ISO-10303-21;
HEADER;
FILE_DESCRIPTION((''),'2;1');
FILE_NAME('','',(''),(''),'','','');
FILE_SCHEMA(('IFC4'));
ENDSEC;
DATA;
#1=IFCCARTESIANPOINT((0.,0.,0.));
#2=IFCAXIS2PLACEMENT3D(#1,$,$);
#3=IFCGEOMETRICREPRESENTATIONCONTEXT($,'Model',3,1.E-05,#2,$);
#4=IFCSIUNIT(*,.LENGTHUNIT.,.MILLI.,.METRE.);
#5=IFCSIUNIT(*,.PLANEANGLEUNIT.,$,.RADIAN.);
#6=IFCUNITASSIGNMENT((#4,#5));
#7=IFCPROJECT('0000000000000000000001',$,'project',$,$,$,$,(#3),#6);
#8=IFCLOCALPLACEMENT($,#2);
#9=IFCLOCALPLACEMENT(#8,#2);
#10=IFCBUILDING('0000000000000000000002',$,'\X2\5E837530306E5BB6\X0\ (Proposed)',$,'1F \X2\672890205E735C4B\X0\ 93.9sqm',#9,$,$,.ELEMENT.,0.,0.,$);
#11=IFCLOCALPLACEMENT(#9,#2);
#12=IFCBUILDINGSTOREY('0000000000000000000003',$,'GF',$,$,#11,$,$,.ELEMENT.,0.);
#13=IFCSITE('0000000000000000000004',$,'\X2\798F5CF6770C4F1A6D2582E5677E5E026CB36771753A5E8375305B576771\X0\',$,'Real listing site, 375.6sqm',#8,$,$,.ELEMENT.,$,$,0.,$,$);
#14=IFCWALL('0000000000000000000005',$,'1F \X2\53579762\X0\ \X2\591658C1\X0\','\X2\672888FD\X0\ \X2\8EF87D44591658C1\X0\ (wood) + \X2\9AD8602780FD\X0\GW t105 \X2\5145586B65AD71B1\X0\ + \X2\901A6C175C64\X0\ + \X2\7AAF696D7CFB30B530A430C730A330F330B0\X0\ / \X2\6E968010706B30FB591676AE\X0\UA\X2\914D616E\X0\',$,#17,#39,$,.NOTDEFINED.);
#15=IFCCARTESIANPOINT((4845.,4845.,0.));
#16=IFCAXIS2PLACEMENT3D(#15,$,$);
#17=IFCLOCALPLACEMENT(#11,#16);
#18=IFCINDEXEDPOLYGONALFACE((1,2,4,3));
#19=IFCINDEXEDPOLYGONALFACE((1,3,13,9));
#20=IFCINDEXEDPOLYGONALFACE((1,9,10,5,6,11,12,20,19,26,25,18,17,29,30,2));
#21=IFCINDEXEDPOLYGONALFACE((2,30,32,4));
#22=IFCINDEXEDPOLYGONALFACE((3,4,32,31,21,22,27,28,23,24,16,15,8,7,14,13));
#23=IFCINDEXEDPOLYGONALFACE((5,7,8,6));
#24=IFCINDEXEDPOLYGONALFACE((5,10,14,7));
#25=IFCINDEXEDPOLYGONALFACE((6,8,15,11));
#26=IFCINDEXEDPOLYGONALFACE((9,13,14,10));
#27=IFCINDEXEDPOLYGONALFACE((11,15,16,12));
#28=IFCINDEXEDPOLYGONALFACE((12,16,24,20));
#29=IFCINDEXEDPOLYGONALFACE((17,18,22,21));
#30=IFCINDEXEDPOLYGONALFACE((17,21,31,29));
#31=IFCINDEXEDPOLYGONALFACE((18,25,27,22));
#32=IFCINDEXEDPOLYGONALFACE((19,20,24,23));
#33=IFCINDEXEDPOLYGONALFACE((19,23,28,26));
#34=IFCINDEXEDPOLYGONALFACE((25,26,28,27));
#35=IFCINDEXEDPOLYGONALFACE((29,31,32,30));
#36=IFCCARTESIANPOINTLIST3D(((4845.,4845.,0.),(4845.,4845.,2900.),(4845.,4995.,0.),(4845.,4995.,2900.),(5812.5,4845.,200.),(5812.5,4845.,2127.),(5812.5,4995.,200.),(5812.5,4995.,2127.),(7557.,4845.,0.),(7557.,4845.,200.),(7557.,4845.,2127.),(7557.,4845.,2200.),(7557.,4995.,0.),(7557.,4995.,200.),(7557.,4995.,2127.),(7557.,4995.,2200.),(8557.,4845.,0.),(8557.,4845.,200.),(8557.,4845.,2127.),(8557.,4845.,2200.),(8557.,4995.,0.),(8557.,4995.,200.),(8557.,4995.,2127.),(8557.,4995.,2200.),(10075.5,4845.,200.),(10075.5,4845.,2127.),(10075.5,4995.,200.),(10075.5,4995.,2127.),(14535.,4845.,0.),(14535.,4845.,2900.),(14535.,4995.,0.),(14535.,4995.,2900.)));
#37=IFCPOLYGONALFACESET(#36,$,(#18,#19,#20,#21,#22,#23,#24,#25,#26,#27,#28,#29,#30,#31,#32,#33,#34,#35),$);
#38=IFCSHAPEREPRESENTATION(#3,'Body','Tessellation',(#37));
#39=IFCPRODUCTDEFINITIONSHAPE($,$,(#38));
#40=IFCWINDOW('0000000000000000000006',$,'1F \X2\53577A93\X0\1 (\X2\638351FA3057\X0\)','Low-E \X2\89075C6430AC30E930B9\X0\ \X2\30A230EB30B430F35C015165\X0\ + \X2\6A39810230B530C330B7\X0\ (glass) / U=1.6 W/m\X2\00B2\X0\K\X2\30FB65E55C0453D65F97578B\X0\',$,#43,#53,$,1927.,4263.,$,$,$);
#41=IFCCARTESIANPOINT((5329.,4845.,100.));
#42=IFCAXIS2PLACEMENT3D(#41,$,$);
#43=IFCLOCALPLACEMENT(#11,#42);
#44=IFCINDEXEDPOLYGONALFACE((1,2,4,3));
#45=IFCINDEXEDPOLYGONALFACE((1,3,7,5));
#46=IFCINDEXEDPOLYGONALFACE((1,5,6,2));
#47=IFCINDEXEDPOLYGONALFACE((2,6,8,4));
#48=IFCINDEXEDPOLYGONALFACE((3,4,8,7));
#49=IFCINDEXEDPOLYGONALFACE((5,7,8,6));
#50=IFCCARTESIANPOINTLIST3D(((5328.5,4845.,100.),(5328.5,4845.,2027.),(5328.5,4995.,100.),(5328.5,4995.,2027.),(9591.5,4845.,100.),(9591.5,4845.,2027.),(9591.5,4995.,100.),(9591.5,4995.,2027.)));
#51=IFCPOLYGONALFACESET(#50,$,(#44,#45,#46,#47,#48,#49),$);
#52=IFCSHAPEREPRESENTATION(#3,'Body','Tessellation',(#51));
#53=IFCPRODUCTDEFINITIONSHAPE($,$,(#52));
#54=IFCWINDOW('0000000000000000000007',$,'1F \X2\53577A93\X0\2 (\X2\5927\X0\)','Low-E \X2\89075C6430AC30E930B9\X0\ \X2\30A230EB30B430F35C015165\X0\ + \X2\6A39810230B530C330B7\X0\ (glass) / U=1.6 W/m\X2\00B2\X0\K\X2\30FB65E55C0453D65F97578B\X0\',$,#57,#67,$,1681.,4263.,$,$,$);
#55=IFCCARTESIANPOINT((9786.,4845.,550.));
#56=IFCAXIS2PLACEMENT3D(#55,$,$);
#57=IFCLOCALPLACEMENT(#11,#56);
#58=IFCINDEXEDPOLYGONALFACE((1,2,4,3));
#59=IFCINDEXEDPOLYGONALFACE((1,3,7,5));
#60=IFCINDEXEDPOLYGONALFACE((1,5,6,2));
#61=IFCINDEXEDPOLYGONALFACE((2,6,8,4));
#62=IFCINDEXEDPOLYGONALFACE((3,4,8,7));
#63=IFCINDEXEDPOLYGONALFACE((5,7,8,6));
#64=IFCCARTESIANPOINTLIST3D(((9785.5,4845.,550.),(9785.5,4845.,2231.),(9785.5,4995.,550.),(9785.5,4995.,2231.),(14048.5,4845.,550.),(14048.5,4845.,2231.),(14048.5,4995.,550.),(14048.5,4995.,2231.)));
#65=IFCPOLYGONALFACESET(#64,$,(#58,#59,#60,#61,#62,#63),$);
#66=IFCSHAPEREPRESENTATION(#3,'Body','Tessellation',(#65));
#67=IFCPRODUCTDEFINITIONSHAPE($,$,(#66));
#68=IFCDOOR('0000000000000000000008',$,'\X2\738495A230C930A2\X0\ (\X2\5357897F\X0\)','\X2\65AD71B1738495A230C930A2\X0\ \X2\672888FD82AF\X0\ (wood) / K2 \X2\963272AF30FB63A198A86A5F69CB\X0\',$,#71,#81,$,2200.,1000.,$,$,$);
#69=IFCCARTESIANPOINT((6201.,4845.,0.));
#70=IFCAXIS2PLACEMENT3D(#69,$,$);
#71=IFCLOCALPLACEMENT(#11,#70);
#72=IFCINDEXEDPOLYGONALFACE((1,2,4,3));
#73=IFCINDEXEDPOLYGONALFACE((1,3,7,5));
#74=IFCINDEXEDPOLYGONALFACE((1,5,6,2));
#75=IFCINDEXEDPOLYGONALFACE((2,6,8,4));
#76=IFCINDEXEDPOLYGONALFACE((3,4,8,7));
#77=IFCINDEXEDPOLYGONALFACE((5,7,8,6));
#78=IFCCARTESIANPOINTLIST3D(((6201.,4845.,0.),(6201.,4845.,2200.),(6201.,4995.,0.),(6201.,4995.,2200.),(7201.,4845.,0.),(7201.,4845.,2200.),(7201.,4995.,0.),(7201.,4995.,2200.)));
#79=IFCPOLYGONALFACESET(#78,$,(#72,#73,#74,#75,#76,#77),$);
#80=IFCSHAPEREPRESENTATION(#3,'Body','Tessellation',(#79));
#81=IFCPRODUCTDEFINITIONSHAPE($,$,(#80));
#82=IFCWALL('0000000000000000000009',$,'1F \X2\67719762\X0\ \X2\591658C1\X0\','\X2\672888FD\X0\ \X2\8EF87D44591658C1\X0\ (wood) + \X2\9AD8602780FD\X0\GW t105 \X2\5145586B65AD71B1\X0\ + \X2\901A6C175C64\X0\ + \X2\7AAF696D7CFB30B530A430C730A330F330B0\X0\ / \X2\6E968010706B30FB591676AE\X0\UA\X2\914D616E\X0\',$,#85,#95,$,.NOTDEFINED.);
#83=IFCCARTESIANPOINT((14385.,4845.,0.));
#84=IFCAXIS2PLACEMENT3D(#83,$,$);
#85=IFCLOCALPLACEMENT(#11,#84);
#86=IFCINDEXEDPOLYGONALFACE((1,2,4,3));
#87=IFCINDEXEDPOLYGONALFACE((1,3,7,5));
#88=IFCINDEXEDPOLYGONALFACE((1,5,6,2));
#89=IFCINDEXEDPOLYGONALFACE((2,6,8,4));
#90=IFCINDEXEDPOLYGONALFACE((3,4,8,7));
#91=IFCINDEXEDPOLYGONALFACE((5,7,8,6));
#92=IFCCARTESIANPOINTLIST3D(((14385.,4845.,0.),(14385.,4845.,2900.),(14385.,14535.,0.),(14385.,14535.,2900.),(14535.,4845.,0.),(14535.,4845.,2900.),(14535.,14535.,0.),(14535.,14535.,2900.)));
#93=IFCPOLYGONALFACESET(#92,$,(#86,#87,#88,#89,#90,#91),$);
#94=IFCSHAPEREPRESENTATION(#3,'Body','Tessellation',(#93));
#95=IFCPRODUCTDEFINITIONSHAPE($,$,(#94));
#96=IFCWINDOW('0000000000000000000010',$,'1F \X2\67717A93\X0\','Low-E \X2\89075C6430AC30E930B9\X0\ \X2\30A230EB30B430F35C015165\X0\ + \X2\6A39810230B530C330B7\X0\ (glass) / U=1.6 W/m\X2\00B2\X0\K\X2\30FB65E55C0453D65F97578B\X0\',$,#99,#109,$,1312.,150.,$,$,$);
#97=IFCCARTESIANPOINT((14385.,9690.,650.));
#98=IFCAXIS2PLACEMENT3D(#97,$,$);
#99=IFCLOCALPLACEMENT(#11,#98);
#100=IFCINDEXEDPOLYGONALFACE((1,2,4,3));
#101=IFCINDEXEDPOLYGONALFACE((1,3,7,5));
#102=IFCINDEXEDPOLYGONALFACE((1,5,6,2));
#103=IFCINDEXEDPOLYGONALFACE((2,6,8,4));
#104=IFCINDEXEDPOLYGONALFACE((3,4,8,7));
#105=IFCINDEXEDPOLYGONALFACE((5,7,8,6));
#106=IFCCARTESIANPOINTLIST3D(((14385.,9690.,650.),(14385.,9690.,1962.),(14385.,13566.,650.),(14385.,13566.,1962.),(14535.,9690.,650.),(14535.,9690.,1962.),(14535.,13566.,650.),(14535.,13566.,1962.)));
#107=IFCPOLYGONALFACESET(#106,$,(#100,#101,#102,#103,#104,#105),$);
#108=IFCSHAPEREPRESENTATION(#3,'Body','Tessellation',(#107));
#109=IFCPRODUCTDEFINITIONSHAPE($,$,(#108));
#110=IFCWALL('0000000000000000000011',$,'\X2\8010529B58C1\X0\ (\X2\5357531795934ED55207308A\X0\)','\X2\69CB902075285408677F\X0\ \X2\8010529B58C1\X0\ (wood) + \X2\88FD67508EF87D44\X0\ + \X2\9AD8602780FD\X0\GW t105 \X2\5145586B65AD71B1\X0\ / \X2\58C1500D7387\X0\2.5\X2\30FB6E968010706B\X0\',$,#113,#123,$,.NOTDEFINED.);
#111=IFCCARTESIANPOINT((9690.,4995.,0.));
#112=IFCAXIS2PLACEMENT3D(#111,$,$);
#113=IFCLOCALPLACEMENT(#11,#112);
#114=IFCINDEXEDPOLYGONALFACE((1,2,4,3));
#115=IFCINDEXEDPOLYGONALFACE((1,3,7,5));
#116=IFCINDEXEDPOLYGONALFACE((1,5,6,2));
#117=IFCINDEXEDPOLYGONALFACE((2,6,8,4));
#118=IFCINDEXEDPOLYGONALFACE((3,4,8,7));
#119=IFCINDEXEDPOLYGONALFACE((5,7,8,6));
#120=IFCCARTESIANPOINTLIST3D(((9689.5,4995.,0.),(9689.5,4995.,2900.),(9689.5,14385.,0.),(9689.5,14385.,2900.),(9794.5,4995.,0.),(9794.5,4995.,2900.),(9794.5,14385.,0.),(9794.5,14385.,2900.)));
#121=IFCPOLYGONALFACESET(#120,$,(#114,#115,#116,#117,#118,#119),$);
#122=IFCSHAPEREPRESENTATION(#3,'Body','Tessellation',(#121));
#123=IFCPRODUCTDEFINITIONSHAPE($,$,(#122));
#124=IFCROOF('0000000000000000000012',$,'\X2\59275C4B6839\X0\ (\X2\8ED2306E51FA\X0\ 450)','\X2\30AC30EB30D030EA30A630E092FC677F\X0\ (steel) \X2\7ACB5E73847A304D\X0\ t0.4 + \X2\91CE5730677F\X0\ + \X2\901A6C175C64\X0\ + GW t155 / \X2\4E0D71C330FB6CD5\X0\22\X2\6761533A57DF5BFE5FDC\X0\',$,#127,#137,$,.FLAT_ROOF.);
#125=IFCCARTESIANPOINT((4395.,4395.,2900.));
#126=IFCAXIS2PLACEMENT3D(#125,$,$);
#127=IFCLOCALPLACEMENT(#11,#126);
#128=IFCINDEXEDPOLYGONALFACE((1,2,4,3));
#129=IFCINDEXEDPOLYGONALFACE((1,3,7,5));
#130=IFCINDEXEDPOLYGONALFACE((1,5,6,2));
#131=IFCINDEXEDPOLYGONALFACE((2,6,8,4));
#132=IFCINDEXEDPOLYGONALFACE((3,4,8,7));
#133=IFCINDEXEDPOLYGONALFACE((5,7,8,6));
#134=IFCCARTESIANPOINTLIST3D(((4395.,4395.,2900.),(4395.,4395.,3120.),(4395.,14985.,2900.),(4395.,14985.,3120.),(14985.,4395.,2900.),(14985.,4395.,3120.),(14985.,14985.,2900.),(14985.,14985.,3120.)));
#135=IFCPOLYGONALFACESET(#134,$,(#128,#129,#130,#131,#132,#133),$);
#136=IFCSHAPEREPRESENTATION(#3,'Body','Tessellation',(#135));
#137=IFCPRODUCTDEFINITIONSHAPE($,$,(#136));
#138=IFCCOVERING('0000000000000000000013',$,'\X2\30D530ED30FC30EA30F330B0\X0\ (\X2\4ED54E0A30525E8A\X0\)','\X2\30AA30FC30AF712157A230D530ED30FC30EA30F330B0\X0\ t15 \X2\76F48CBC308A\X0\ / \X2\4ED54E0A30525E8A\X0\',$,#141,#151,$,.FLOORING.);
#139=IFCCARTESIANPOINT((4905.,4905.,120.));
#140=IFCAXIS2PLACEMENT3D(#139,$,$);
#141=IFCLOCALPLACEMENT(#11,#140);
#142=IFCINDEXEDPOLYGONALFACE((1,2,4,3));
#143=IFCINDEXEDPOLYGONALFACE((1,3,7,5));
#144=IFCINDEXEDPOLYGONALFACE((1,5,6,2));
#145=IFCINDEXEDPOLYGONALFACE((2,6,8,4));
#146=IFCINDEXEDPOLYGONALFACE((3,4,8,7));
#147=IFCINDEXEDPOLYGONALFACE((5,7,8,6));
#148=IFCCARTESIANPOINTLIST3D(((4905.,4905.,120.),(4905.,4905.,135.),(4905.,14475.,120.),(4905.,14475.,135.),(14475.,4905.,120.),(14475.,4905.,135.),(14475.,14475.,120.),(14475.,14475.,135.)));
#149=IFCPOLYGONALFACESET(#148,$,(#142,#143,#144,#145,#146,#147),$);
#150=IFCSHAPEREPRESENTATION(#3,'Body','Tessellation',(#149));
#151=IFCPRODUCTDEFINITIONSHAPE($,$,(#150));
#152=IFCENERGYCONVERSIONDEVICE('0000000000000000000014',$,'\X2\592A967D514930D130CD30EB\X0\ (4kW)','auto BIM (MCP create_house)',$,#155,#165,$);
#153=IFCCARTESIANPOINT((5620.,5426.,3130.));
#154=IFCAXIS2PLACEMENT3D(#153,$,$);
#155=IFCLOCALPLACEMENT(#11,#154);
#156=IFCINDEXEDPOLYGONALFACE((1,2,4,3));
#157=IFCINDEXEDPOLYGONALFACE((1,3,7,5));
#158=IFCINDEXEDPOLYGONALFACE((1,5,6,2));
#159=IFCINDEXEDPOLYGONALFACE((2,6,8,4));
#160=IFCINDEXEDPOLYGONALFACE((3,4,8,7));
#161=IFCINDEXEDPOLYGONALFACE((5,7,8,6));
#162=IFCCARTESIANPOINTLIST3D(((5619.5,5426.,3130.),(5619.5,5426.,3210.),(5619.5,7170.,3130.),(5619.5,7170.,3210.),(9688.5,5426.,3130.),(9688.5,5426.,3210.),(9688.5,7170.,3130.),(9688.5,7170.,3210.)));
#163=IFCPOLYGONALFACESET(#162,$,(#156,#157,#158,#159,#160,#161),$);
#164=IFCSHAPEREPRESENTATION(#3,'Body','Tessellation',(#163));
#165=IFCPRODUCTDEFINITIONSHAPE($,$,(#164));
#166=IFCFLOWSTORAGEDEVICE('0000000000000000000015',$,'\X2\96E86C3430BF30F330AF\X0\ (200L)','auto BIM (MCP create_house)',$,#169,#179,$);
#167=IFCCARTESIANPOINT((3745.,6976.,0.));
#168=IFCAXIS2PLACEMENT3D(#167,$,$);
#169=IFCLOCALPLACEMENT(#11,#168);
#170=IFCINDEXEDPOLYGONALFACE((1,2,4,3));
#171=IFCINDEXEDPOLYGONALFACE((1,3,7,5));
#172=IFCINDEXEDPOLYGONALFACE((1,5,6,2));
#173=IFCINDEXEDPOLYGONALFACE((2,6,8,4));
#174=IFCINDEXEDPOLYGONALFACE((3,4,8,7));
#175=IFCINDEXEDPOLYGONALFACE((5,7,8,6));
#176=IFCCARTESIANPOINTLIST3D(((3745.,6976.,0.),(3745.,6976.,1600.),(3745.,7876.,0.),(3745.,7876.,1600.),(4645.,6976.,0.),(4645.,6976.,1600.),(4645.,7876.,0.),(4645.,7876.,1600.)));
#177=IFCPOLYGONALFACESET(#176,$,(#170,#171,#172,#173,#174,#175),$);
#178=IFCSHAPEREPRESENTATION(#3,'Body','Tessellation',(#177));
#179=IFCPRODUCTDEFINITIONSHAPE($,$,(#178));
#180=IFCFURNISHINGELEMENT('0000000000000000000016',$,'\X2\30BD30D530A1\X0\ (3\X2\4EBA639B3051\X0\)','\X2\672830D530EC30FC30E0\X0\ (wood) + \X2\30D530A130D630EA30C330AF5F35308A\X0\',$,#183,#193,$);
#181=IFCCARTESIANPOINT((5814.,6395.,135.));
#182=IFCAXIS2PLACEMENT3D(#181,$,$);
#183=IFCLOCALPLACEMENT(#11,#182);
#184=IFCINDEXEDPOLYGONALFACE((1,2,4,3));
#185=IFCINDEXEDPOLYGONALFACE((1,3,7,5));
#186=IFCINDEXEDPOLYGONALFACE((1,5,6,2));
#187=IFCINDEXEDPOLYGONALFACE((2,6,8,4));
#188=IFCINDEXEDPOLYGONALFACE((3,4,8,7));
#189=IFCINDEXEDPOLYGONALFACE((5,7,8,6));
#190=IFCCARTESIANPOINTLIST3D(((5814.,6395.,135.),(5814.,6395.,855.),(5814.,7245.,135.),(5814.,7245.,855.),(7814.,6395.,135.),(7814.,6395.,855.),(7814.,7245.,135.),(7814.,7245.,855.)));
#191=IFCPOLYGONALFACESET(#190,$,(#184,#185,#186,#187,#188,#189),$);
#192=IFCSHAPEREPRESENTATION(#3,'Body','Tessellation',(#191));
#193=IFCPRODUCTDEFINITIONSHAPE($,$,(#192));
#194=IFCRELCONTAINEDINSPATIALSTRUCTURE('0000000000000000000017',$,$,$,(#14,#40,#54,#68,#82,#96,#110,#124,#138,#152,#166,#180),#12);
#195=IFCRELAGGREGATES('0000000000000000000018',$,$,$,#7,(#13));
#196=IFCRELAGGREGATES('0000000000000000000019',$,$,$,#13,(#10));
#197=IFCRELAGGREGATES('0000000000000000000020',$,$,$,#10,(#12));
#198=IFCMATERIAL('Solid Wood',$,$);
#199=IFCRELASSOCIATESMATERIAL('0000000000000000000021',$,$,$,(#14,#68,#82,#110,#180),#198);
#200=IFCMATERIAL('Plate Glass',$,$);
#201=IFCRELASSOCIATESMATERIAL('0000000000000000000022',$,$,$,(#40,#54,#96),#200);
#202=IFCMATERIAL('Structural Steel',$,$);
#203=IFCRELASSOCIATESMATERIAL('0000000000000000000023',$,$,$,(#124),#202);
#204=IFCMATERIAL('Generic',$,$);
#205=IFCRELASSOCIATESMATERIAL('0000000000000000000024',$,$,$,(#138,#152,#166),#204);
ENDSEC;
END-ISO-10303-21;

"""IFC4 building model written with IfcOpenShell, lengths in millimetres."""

from ifc_helpers import new_model, si_unit, frame, frame_2d, origin, place, context, project, spatial, rectangle, extrude, material, element, fill, save


model = new_model("IFC4")

# Units and contexts
model_context = context("Model", 3, precision=1e-05, world=origin())
ifc_project = project(units=[si_unit("LENGTHUNIT", "METRE", prefix="MILLI"), si_unit("PLANEANGLEUNIT", "RADIAN")], contexts=[model_context])

# Site, building, storey
site_placement = place(None, origin())
site = spatial("IfcSite", under=ifc_project, at=site_placement, Name="福島県会津若松市河東町広田字東", ObjectType="Real listing site, 375.6sqm", CompositionType="ELEMENT", RefElevation=0.0)
building_placement = place(site_placement, origin())
building = spatial("IfcBuilding", under=site, at=building_placement, Name="広田の家 (Proposed)", ObjectType="1F 木造平屋 93.9sqm", CompositionType="ELEMENT", ElevationOfRefHeight=0.0, ElevationOfTerrain=0.0)
storey_placement = place(building_placement, origin())
storey = spatial("IfcBuildingStorey", under=building, at=storey_placement, Name="GF", CompositionType="ELEMENT", Elevation=0.0)

# Shared definitions
ifc_material_1 = material(Name="Solid Wood")

# Wall, openings, windows, door
wall_1_placement = place(storey_placement, frame((4845.0, 4845.0, 0.0)))
wall_1 = element("IfcWall", 1, at=wall_1_placement, inside=storey, material=ifc_material_1, Name="1F 南面 外壁", Description="木製 軸組外壁 (wood) + 高性能GW t105 充填断熱 + 通気層 + 窯業系サイディング / 準耐火・外皮UA配慮", PredefinedType="NOTDEFINED", context=model_context, shape_type="SweptSolid", body=[
    extrude(rectangle(XDim=9690.0, YDim=150.0, at=frame_2d((4845.0, 75.0))), frame((4845.0, 4845.0, 0.0)), (0.0, 0.0, 1.0), 2900.0),
])
opening_1_placement = place(storey_placement, frame((5329.0, 4845.0, 100.0)))
opening_1 = element("IfcOpeningElement", 2, at=opening_1_placement, cuts=wall_1, PredefinedType="NOTDEFINED", context=model_context, shape_type="SweptSolid", body=[
    extrude(rectangle(XDim=4263.0, YDim=150.0, at=frame_2d((2131.0, 75.0))), frame((5329.0, 4845.0, 100.0)), (0.0, 0.0, 1.0), 1927.0),
])
opening_2_placement = place(storey_placement, frame((9786.0, 4845.0, 550.0)))
opening_2 = element("IfcOpeningElement", 3, at=opening_2_placement, cuts=wall_1, PredefinedType="NOTDEFINED", context=model_context, shape_type="SweptSolid", body=[
    extrude(rectangle(XDim=4263.0, YDim=150.0, at=frame_2d((2131.0, 75.0))), frame((9786.0, 4845.0, 550.0)), (0.0, 0.0, 1.0), 1681.0),
])
opening_3_placement = place(storey_placement, frame((6201.0, 4845.0, 0.0)))
opening_3 = element("IfcOpeningElement", 4, at=opening_3_placement, cuts=wall_1, PredefinedType="NOTDEFINED", context=model_context, shape_type="SweptSolid", body=[
    extrude(rectangle(XDim=1000.0, YDim=150.0, at=frame_2d((500.0, 75.0))), frame((6201.0, 4845.0, 0.0)), (0.0, 0.0, 1.0), 2200.0),
])
ifc_material_2 = material(Name="Plate Glass")
window_1_placement = place(storey_placement, frame((5329.0, 4845.0, 100.0)))
window_1 = element("IfcWindow", 5, at=window_1_placement, inside=storey, material=ifc_material_2, Name="1F 南窓1 (掃出し)", Description="Low-E 複層ガラス アルゴン封入 + 樹脂サッシ (glass) / U=1.6 W/m²K・日射取得型", OverallHeight=1927.0, OverallWidth=4263.0, context=model_context, shape_type="SweptSolid", body=[
    extrude(rectangle(XDim=4263.0, YDim=150.0, at=frame_2d((2131.0, 75.0))), frame((5329.0, 4845.0, 100.0)), (0.0, 0.0, 1.0), 1927.0),
])
fill(opening_1, window_1)
window_2_placement = place(storey_placement, frame((9786.0, 4845.0, 550.0)))
window_2 = element("IfcWindow", 6, at=window_2_placement, inside=storey, material=ifc_material_2, Name="1F 南窓2 (大)", Description="Low-E 複層ガラス アルゴン封入 + 樹脂サッシ (glass) / U=1.6 W/m²K・日射取得型", OverallHeight=1681.0, OverallWidth=4263.0, context=model_context, shape_type="SweptSolid", body=[
    extrude(rectangle(XDim=4263.0, YDim=150.0, at=frame_2d((2131.0, 75.0))), frame((9786.0, 4845.0, 550.0)), (0.0, 0.0, 1.0), 1681.0),
])
fill(opening_2, window_2)
door_placement = place(storey_placement, frame((6201.0, 4845.0, 0.0)))
door = element("IfcDoor", 7, at=door_placement, inside=storey, material=ifc_material_1, Name="玄関ドア (南西)", Description="断熱玄関ドア 木製芯 (wood) / K2 防犯・採風機構", OverallHeight=2200.0, OverallWidth=1000.0, context=model_context, shape_type="SweptSolid", body=[
    extrude(rectangle(XDim=1000.0, YDim=150.0, at=frame_2d((500.0, 75.0))), frame((6201.0, 4845.0, 0.0)), (0.0, 0.0, 1.0), 2200.0),
])
fill(opening_3, door)

# Wall, opening, window
wall_2_placement = place(storey_placement, frame((14385.0, 4845.0, 0.0)))
wall_2 = element("IfcWall", 8, at=wall_2_placement, inside=storey, material=ifc_material_1, Name="1F 東面 外壁", Description="木製 軸組外壁 (wood) + 高性能GW t105 充填断熱 + 通気層 + 窯業系サイディング / 準耐火・外皮UA配慮", PredefinedType="NOTDEFINED", context=model_context, shape_type="SweptSolid", body=[
    extrude(rectangle(XDim=150.0, YDim=9690.0, at=frame_2d((75.0, 4845.0))), frame((14385.0, 4845.0, 0.0)), (0.0, 0.0, 1.0), 2900.0),
])
opening_4_placement = place(storey_placement, frame((14385.0, 9690.0, 650.0)))
opening_4 = element("IfcOpeningElement", 9, at=opening_4_placement, cuts=wall_2, PredefinedType="NOTDEFINED", context=model_context, shape_type="SweptSolid", body=[
    extrude(rectangle(XDim=150.0, YDim=3876.0, at=frame_2d((75.0, 1938.0))), frame((14385.0, 9690.0, 650.0)), (0.0, 0.0, 1.0), 1312.0),
])
window_3_placement = place(storey_placement, frame((14385.0, 9690.0, 650.0)))
window_3 = element("IfcWindow", 10, at=window_3_placement, inside=storey, material=ifc_material_2, Name="1F 東窓", Description="Low-E 複層ガラス アルゴン封入 + 樹脂サッシ (glass) / U=1.6 W/m²K・日射取得型", OverallHeight=1312.0, OverallWidth=150.0, context=model_context, shape_type="SweptSolid", body=[
    extrude(rectangle(XDim=150.0, YDim=3876.0, at=frame_2d((75.0, 1938.0))), frame((14385.0, 9690.0, 650.0)), (0.0, 0.0, 1.0), 1312.0),
])
fill(opening_4, window_3)

# Wall
wall_3_placement = place(storey_placement, frame((9690.0, 4995.0, 0.0)))
element("IfcWall", 11, at=wall_3_placement, inside=storey, material=ifc_material_1, Name="耐力壁 (南北間仕切り)", Description="構造用合板 耐力壁 (wood) + 製材軸組 + 高性能GW t105 充填断熱 / 壁倍率2.5・準耐火", PredefinedType="NOTDEFINED", context=model_context, shape_type="SweptSolid", body=[
    extrude(rectangle(XDim=105.0, YDim=9390.0, at=frame_2d((52.0, 4695.0))), frame((9690.0, 4995.0, 0.0)), (0.0, 0.0, 1.0), 2900.0),
])

# Roof
ifc_material_3 = material(Name="Structural Steel")
roof_placement = place(storey_placement, frame((4395.0, 4395.0, 2900.0)))
element("IfcRoof", 12, at=roof_placement, inside=storey, material=ifc_material_3, Name="大屋根 (軒の出 450)", Description="ガルバリウム鋼板 (steel) 立平葺き t0.4 + 野地板 + 通気層 + GW t155 / 不燃・法22条区域対応", PredefinedType="FLAT_ROOF", context=model_context, shape_type="SweptSolid", body=[
    extrude(rectangle(XDim=10590.0, YDim=10590.0, at=frame_2d((5295.0, 5295.0))), frame((4395.0, 4395.0, 2900.0)), (0.0, 0.0, 1.0), 220.0),
])

# Covering
ifc_material_4 = material(Name="Generic")
covering_placement = place(storey_placement, frame((4905.0, 4905.0, 120.0)))
element("IfcCovering", 13, at=covering_placement, inside=storey, material=ifc_material_4, Name="フローリング (仕上げ床)", Description="オーク無垢フローリング t15 直貼り / 仕上げ床", PredefinedType="FLOORING", context=model_context, shape_type="SweptSolid", body=[
    extrude(rectangle(XDim=9570.0, YDim=9570.0, at=frame_2d((4785.0, 4785.0))), frame((4905.0, 4905.0, 120.0)), (0.0, 0.0, 1.0), 15.0),
])

# Energy conversion device
energy_conversion_device_placement = place(storey_placement, frame((5620.0, 5426.0, 3130.0)))
element("IfcEnergyConversionDevice", 14, at=energy_conversion_device_placement, inside=storey, material=ifc_material_4, Name="太陽光パネル (4kW)", Description="auto BIM (MCP create_house)", context=model_context, shape_type="SweptSolid", body=[
    extrude(rectangle(XDim=4069.0, YDim=1744.0, at=frame_2d((2034.0, 872.0))), frame((5620.0, 5426.0, 3130.0)), (0.0, 0.0, 1.0), 80.0),
])

# Flow storage device
flow_storage_device_placement = place(storey_placement, frame((3745.0, 6976.0, 0.0)))
element("IfcFlowStorageDevice", 15, at=flow_storage_device_placement, inside=storey, material=ifc_material_4, Name="雨水タンク (200L)", Description="auto BIM (MCP create_house)", context=model_context, shape_type="SweptSolid", body=[
    extrude(rectangle(XDim=900.0, YDim=900.0, at=frame_2d((450.0, 450.0))), frame((3745.0, 6976.0, 0.0)), (0.0, 0.0, 1.0), 1600.0),
])

# Furnishing element
furnishing_1_placement = place(storey_placement, frame((5814.0, 6395.0, 135.0)))
element("IfcFurnishingElement", 16, at=furnishing_1_placement, inside=storey, material=ifc_material_1, Name="ソファ (3人掛け)", Description="木フレーム (wood) + ファブリック張り", context=model_context, shape_type="SweptSolid", body=[
    extrude(rectangle(XDim=2000.0, YDim=850.0, at=frame_2d((1000.0, 425.0))), frame((5814.0, 6395.0, 135.0)), (0.0, 0.0, 1.0), 720.0),
])

save(model, "model.ifc")
